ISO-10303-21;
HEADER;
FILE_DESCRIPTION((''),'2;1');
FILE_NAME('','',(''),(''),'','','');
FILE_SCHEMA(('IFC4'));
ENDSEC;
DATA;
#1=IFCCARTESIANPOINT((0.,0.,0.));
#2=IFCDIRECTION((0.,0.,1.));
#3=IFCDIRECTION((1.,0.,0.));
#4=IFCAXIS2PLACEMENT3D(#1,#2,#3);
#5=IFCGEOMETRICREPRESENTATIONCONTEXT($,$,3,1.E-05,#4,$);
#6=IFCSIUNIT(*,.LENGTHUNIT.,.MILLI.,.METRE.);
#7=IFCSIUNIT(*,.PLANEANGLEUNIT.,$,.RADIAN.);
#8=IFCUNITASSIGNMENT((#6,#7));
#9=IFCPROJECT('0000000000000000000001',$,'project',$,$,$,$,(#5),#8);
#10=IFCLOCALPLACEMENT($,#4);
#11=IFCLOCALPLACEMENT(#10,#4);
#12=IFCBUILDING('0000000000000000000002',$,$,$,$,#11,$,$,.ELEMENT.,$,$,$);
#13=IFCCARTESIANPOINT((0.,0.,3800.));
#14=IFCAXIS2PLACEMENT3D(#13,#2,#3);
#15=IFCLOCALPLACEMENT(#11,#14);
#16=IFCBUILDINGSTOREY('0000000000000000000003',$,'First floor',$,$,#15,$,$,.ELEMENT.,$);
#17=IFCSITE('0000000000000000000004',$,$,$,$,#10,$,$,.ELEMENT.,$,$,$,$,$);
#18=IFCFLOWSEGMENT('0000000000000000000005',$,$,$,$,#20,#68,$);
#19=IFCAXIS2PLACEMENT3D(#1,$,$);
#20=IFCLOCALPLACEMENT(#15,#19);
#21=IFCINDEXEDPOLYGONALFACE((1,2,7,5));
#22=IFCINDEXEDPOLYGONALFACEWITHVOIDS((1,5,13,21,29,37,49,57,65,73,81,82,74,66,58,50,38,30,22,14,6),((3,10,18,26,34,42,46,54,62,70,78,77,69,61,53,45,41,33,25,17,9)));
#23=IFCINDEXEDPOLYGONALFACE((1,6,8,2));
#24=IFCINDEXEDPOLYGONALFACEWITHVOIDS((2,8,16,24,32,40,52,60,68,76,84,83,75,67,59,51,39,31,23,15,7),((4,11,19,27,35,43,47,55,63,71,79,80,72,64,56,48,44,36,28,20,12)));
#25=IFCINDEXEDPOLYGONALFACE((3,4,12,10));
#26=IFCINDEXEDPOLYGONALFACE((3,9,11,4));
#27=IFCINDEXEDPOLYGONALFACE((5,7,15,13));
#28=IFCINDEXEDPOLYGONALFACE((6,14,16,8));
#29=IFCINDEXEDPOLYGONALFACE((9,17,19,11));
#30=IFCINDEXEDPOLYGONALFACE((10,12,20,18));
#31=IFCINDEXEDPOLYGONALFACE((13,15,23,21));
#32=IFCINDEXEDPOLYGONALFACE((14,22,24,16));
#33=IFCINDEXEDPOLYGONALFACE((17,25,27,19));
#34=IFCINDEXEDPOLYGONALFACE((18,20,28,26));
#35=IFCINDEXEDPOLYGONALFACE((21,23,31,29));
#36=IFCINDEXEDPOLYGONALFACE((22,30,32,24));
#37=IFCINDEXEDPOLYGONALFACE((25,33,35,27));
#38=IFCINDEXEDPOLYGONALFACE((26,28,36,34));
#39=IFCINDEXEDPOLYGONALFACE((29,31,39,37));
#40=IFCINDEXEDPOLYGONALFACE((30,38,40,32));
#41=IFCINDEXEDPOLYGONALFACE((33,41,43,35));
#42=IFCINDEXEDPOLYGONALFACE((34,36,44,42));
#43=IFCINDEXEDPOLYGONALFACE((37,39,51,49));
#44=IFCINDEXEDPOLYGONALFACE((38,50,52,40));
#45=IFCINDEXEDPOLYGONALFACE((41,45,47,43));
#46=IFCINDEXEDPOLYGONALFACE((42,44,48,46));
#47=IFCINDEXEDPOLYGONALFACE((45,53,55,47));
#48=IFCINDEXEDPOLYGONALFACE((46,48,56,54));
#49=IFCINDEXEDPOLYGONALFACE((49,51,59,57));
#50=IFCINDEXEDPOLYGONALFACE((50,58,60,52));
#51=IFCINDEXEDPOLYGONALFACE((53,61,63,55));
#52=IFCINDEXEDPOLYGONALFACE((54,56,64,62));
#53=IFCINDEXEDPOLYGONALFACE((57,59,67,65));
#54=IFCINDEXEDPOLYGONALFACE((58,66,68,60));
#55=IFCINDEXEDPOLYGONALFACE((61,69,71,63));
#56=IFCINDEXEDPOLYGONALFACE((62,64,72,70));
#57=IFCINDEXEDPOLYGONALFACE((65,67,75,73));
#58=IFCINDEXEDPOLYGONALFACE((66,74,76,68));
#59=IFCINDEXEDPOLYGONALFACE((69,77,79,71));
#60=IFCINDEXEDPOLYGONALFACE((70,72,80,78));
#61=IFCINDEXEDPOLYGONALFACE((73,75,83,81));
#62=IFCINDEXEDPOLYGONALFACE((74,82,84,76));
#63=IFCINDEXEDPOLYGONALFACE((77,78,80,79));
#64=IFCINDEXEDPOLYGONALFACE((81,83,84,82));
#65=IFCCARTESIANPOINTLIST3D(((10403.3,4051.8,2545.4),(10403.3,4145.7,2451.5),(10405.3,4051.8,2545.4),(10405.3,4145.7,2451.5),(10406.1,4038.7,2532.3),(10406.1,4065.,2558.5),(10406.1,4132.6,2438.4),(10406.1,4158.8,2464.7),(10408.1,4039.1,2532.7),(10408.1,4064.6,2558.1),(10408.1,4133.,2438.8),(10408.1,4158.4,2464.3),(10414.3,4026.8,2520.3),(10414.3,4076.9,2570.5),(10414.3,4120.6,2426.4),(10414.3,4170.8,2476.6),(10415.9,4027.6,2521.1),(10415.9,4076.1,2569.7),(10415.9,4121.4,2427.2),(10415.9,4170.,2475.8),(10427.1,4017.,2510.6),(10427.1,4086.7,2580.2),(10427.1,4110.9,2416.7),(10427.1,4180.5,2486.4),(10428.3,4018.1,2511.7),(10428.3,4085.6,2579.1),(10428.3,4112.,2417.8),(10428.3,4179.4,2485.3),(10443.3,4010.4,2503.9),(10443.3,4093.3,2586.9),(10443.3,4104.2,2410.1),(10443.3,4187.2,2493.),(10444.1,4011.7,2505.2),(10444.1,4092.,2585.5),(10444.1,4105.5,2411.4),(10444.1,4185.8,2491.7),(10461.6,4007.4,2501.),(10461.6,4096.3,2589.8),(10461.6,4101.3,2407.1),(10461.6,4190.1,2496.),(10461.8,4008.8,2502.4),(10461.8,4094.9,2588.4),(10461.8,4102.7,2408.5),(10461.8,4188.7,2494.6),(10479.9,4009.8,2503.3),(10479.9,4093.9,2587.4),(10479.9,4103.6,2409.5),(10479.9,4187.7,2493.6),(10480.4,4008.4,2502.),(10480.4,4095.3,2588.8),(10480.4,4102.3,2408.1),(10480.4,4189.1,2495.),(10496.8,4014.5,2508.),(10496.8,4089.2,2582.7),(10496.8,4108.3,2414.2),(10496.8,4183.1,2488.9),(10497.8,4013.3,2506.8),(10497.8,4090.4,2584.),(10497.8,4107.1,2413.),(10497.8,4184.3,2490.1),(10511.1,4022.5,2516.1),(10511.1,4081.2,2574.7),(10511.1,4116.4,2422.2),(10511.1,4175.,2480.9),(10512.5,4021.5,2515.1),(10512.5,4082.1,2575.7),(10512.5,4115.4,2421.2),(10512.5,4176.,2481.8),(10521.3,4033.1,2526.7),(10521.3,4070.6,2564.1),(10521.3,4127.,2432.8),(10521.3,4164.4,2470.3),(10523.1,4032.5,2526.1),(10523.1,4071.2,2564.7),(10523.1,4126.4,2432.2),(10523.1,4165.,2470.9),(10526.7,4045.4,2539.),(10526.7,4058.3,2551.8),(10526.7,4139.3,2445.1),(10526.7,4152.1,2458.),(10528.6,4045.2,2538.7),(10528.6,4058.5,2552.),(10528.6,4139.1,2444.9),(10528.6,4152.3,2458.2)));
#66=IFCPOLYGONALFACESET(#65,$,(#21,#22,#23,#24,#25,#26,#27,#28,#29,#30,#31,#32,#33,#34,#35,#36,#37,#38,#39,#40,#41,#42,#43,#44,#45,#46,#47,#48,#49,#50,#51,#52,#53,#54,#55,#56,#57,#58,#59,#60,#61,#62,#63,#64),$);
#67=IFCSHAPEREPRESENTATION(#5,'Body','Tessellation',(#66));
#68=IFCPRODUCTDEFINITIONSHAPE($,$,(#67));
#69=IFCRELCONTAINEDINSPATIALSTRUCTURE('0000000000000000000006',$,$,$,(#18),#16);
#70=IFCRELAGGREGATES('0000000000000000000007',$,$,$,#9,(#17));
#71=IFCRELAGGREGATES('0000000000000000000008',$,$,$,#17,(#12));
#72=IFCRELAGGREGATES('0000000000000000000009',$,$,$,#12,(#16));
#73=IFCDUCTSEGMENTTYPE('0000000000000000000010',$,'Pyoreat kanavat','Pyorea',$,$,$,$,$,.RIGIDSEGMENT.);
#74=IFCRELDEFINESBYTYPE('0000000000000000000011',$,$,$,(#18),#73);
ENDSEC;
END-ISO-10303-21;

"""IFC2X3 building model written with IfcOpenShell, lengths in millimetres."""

from ifc_helpers import new_model, si_unit, frame, origin_with_axes, origin_2d_with_axis, place, context, project, spatial, hollow_circle, extrude, source, transform, mapped, type_object, element, save


model = new_model("IFC2X3")

# Units and contexts
context_of_model = context(None, 3, precision=1e-05, world=origin_with_axes())
ifc_project = project(units=[si_unit("LENGTHUNIT", "METRE", prefix="MILLI"), si_unit("PLANEANGLEUNIT", "RADIAN")], contexts=[context_of_model])

# Site, building, storey
site_placement = place(None, origin_with_axes())
site = spatial("IfcSite", under=ifc_project, at=site_placement, CompositionType="ELEMENT")
building_placement = place(site_placement, origin_with_axes())
building = spatial("IfcBuilding", under=site, at=building_placement, CompositionType="ELEMENT")
storey_placement = place(building_placement, frame((0.0, 0.0, 3800.0), z_axis=(0.0, 0.0, 1.0), x_axis=(1.0, 0.0, 0.0)))
storey = spatial("IfcBuildingStorey", under=building, at=storey_placement, Name="First floor", CompositionType="ELEMENT")

# Flow segment
duct_segment_type_1 = type_object("IfcDuctSegmentType", Name="Pyoreat kanavat", Description="Pyorea", PredefinedType="RIGIDSEGMENT")
shared_shape_1 = source(origin_with_axes(), context_of_model, "Body", "SweptSolid", [
    extrude(hollow_circle(Radius=63.0, WallThickness=2.0, at=origin_2d_with_axis()), frame((0.0, 0.0, 0.0), z_axis=(1.0, 0.0, 0.0), x_axis=(0.0, 1.0, 0.0)), (0.0, 0.0, 1.0), 306.0),
])
flow_segment_1_placement = place(storey_placement, frame((10466.3, 4051.8, 2545.4), z_axis=(0.0, 0.707107, 0.707107), x_axis=(0.0, 0.707107, -0.707107)))
element("IfcFlowSegment", 1, at=flow_segment_1_placement, inside=storey, type_object=duct_segment_type_1, context=context_of_model, shape_type="MappedRepresentation", body=[
    mapped(shared_shape_1, transform((0.0, 0.0, 0.0), scale=0.43373, scale2=1.0, scale3=1.0, uniform=False)),
])

save(model, "model.ifc")
